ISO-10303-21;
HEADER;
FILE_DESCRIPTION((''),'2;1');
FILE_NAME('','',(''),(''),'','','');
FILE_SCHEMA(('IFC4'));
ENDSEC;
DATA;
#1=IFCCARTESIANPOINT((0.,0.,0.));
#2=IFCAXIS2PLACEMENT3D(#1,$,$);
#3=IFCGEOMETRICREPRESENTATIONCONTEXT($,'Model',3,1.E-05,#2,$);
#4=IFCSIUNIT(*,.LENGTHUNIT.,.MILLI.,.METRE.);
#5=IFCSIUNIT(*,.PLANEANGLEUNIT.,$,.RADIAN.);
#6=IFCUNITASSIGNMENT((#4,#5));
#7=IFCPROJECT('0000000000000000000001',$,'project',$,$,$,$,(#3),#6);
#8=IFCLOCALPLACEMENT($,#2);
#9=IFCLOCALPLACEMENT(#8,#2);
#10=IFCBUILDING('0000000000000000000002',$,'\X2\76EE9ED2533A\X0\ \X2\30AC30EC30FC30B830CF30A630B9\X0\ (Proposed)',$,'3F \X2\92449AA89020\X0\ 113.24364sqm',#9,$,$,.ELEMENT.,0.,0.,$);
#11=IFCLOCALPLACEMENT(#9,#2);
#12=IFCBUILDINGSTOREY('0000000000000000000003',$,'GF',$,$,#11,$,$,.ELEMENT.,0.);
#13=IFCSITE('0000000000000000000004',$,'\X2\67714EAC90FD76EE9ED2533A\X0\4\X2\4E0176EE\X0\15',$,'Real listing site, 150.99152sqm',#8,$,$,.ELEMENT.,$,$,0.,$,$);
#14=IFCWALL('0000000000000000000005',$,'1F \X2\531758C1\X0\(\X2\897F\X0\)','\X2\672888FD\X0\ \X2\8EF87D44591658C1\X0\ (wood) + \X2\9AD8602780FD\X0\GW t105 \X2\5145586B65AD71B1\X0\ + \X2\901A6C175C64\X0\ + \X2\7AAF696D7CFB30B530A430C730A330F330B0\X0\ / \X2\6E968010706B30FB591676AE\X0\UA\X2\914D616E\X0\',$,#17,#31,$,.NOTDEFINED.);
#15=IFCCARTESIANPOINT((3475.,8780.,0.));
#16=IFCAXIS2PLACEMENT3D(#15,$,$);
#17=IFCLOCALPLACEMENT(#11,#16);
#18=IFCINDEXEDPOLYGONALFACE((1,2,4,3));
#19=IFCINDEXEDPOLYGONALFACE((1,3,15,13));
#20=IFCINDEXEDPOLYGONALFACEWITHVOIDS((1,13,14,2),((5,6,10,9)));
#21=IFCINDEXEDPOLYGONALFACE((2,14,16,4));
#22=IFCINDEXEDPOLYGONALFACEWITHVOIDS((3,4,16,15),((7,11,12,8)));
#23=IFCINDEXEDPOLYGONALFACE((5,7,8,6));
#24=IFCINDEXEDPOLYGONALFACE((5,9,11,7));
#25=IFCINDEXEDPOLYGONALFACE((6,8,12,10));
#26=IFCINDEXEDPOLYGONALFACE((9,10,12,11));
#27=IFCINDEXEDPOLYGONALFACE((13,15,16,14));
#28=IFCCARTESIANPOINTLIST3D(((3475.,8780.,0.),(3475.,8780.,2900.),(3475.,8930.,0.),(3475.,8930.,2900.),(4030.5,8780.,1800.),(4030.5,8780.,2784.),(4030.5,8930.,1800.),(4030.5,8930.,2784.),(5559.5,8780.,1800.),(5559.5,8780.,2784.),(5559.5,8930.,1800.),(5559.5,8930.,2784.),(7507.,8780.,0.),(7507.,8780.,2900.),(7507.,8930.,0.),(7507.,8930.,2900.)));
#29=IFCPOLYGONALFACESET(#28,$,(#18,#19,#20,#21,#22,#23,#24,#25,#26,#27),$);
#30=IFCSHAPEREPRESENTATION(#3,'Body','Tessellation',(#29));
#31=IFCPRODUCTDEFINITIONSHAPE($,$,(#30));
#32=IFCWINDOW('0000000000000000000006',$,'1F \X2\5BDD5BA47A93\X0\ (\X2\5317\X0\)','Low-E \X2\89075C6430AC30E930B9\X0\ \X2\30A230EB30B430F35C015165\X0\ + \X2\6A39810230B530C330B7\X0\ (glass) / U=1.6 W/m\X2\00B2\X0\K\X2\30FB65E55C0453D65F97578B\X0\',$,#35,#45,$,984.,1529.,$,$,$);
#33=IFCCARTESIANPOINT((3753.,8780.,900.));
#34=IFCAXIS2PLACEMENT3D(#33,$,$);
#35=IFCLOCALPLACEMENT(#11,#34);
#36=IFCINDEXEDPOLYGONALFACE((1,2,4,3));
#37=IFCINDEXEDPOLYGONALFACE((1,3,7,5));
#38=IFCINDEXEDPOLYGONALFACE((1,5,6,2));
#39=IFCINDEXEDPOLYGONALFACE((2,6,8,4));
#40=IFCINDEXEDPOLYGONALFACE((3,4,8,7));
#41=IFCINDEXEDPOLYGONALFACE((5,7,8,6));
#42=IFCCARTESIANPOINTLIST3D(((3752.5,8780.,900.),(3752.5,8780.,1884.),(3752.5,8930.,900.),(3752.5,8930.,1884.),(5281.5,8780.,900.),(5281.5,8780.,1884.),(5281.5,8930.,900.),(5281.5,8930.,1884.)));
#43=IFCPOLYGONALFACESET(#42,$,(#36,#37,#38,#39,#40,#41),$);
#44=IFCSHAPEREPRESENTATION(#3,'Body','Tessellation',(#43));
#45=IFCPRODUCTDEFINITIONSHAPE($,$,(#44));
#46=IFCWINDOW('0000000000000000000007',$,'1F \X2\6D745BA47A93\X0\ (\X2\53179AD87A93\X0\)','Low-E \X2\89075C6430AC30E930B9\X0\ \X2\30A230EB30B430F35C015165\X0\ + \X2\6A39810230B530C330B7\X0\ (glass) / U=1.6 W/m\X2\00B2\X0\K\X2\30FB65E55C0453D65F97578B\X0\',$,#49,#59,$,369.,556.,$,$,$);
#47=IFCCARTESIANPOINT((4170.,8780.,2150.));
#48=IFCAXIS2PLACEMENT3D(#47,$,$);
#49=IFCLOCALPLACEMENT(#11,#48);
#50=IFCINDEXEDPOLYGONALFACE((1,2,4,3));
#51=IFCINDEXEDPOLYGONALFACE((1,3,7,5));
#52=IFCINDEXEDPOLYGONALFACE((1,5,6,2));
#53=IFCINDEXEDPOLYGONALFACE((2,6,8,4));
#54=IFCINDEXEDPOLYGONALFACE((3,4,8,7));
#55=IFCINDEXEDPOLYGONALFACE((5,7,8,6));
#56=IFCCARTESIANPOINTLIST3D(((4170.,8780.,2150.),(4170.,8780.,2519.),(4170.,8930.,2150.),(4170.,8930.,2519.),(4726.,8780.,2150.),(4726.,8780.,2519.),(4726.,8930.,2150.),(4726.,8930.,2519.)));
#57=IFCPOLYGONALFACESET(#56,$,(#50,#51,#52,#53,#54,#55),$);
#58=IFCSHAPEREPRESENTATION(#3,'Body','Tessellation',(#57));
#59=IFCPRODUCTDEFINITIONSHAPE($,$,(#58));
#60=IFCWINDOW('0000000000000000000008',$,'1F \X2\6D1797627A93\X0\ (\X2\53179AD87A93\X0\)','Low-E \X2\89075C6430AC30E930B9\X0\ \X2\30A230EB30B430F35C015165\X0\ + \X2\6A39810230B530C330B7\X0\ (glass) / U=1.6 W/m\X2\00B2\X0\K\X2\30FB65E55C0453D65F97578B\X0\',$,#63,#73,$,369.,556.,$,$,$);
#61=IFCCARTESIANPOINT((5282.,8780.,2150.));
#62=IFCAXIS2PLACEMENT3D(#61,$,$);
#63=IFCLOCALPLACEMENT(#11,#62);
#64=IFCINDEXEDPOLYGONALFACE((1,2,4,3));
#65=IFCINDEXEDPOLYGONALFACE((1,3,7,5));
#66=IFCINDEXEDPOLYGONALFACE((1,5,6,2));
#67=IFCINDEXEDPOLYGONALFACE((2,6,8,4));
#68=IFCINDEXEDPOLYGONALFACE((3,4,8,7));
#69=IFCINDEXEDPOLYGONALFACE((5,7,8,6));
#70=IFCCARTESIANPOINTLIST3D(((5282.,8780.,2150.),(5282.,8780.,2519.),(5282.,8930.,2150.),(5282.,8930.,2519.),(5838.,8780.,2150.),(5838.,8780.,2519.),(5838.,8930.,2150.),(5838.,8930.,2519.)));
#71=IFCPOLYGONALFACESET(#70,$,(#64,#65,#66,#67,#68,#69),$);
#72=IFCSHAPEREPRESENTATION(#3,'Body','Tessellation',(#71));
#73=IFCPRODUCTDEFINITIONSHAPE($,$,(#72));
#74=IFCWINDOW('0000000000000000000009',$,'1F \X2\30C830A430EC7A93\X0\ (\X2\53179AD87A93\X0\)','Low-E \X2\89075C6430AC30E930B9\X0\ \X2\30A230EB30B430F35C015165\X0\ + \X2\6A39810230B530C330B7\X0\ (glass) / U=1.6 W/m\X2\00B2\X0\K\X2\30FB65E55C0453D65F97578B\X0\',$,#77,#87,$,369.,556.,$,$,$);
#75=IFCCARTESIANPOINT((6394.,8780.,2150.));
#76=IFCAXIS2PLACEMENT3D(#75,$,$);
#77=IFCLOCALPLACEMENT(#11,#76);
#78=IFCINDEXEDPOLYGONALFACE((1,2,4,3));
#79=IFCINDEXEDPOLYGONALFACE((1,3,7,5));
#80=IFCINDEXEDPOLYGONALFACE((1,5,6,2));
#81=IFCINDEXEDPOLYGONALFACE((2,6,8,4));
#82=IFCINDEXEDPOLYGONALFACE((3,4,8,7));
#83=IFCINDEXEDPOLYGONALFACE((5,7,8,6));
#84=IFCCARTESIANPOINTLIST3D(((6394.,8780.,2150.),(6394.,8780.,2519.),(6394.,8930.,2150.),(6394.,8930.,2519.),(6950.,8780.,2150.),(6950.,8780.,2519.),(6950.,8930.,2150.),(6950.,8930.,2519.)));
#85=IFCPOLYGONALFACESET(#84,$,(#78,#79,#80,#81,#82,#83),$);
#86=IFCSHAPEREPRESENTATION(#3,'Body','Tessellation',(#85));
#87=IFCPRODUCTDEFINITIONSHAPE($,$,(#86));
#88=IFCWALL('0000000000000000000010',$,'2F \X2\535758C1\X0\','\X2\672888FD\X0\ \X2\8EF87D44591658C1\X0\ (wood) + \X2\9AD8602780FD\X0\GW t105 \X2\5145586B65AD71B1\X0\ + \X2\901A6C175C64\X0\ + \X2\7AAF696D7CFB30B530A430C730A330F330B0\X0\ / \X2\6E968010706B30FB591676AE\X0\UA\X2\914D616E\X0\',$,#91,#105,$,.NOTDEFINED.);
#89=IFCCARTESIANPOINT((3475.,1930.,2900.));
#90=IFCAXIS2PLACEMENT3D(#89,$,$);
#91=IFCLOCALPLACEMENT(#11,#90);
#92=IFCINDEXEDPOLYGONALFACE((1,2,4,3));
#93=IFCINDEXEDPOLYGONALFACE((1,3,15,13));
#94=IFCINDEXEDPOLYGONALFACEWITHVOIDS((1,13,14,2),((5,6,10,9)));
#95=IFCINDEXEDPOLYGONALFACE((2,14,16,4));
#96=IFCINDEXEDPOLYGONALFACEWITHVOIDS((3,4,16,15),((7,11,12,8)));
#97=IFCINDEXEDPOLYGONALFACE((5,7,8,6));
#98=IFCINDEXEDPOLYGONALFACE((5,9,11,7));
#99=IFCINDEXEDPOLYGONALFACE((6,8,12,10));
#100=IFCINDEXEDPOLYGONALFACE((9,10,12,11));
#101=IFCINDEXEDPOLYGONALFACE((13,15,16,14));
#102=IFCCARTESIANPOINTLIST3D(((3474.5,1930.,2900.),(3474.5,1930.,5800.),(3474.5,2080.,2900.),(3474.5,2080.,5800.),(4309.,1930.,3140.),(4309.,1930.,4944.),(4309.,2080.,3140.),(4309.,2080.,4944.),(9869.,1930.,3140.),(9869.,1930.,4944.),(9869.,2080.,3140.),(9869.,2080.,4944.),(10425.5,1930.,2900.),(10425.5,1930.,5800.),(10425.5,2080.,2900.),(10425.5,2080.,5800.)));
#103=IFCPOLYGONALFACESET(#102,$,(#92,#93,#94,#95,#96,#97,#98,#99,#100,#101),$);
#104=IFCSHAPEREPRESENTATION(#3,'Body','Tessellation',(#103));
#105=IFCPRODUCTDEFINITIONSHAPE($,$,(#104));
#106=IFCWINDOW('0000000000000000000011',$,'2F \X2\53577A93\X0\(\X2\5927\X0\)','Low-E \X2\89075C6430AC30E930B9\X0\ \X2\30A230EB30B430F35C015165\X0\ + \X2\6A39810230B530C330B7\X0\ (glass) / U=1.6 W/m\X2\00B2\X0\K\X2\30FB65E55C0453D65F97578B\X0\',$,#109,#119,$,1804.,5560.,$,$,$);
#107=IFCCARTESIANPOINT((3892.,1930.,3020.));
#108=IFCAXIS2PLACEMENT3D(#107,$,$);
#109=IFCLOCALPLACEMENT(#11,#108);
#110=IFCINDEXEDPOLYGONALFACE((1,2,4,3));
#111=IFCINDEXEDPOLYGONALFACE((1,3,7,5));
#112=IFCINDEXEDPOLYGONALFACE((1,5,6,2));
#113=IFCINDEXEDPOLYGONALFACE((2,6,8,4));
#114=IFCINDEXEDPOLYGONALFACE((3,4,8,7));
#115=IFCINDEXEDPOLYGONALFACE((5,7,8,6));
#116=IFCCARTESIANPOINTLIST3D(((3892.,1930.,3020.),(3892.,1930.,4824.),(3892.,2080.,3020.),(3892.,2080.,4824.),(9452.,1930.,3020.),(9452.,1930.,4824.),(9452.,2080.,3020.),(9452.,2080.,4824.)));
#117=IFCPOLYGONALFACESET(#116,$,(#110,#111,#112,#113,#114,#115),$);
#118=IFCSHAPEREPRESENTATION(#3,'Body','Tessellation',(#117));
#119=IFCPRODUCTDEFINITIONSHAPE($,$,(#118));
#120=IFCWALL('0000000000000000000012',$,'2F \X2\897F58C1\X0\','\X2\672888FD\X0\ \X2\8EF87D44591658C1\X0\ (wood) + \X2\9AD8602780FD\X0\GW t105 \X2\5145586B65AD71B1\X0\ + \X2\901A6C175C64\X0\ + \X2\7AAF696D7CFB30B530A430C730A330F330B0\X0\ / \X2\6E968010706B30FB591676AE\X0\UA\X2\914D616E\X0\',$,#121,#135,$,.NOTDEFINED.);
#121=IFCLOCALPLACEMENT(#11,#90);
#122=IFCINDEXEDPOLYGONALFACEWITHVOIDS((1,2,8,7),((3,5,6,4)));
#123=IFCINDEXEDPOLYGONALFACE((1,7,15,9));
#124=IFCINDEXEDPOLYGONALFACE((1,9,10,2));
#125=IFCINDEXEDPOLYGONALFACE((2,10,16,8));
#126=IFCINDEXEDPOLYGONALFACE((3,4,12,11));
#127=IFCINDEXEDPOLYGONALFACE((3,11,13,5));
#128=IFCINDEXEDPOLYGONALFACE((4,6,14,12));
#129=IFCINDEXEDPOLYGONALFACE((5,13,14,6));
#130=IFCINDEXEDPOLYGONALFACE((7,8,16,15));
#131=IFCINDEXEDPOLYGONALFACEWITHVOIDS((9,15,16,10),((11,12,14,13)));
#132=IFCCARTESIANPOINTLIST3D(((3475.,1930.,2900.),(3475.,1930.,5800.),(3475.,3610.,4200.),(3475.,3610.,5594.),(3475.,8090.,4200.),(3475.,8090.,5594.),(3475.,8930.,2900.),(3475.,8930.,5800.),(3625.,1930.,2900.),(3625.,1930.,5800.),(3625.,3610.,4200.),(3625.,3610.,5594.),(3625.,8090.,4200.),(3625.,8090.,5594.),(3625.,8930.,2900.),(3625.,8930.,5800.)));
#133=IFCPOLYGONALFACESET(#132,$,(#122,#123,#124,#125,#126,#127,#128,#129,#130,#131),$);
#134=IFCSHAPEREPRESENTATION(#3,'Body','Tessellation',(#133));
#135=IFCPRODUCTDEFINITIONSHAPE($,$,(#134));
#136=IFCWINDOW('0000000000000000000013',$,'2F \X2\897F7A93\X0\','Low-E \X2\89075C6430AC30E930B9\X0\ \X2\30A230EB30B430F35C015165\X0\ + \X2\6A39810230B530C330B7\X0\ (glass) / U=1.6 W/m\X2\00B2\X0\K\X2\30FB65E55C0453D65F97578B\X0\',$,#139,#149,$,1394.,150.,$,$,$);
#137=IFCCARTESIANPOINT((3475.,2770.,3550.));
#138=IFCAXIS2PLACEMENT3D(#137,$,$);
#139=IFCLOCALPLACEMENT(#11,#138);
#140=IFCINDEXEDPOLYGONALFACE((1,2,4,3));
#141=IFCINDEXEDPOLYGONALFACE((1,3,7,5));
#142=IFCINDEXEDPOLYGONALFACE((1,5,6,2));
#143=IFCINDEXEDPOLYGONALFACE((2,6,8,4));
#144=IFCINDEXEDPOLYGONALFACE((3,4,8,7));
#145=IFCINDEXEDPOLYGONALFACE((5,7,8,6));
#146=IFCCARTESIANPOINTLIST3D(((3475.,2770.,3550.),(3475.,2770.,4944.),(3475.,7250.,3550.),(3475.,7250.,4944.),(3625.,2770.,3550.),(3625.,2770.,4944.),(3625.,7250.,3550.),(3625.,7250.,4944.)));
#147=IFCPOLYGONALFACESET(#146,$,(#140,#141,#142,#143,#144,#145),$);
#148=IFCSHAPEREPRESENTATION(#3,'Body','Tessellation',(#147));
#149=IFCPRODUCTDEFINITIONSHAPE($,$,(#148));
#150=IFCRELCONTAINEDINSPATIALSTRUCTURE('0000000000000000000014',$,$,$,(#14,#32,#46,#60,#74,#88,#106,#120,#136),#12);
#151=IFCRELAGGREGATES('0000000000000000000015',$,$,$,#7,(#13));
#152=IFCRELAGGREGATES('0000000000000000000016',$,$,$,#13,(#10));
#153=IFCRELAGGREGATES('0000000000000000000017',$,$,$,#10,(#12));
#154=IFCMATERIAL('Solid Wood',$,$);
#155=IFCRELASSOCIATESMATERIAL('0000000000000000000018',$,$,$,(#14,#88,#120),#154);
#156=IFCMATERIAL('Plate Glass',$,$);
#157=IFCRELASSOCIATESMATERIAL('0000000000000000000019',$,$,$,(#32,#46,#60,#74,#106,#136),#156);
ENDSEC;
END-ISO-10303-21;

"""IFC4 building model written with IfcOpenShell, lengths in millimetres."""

from ifc_helpers import new_model, si_unit, frame, frame_2d, origin, place, context, project, spatial, rectangle, extrude, material, element, fill, save


model = new_model("IFC4")

# Units and contexts
model_context = context("Model", 3, precision=1e-05, world=origin())
ifc_project = project(units=[si_unit("LENGTHUNIT", "METRE", prefix="MILLI"), si_unit("PLANEANGLEUNIT", "RADIAN")], contexts=[model_context])

# Site, building, storey
site_placement = place(None, origin())
site = spatial("IfcSite", under=ifc_project, at=site_placement, Name="東京都目黒区4丁目15", ObjectType="Real listing site, 150.99152sqm", CompositionType="ELEMENT", RefElevation=0.0)
building_placement = place(site_placement, origin())
building = spatial("IfcBuilding", under=site, at=building_placement, Name="目黒区 ガレージハウス (Proposed)", ObjectType="3F 鉄骨造 113.24364sqm", CompositionType="ELEMENT", ElevationOfRefHeight=0.0, ElevationOfTerrain=0.0)
storey_placement = place(building_placement, origin())
storey = spatial("IfcBuildingStorey", under=building, at=storey_placement, Name="GF", CompositionType="ELEMENT", Elevation=0.0)

# Shared definitions
ifc_material_1 = material(Name="Solid Wood")

# Shared definitions
ifc_material_2 = material(Name="Plate Glass")

# Wall, openings, windows
wall_1_placement = place(storey_placement, frame((3475.0, 8780.0, 0.0)))
wall_1 = element("IfcWall", 1, at=wall_1_placement, inside=storey, material=ifc_material_1, Name="1F 北壁(西)", Description="木製 軸組外壁 (wood) + 高性能GW t105 充填断熱 + 通気層 + 窯業系サイディング / 準耐火・外皮UA配慮", PredefinedType="NOTDEFINED", context=model_context, shape_type="SweptSolid", body=[
    extrude(rectangle(XDim=4032.0, YDim=150.0, at=frame_2d((2016.0, 75.0))), frame((3475.0, 8780.0, 0.0)), (0.0, 0.0, 1.0), 2900.0),
])
opening_1_placement = place(storey_placement, frame((3753.0, 8780.0, 900.0)))
opening_1 = element("IfcOpeningElement", 2, at=opening_1_placement, cuts=wall_1, PredefinedType="NOTDEFINED", context=model_context, shape_type="SweptSolid", body=[
    extrude(rectangle(XDim=1529.0, YDim=150.0, at=frame_2d((764.0, 75.0))), frame((3753.0, 8780.0, 900.0)), (0.0, 0.0, 1.0), 984.0),
])
opening_2_placement = place(storey_placement, frame((4170.0, 8780.0, 2150.0)))
opening_2 = element("IfcOpeningElement", 3, at=opening_2_placement, cuts=wall_1, PredefinedType="NOTDEFINED", context=model_context, shape_type="SweptSolid", body=[
    extrude(rectangle(XDim=556.0, YDim=150.0, at=frame_2d((278.0, 75.0))), frame((4170.0, 8780.0, 2150.0)), (0.0, 0.0, 1.0), 369.0),
])
opening_3_placement = place(storey_placement, frame((5282.0, 8780.0, 2150.0)))
opening_3 = element("IfcOpeningElement", 4, at=opening_3_placement, cuts=wall_1, PredefinedType="NOTDEFINED", context=model_context, shape_type="SweptSolid", body=[
    extrude(rectangle(XDim=556.0, YDim=150.0, at=frame_2d((278.0, 75.0))), frame((5282.0, 8780.0, 2150.0)), (0.0, 0.0, 1.0), 369.0),
])
opening_4_placement = place(storey_placement, frame((6394.0, 8780.0, 2150.0)))
opening_4 = element("IfcOpeningElement", 5, at=opening_4_placement, cuts=wall_1, PredefinedType="NOTDEFINED", context=model_context, shape_type="SweptSolid", body=[
    extrude(rectangle(XDim=556.0, YDim=150.0, at=frame_2d((278.0, 75.0))), frame((6394.0, 8780.0, 2150.0)), (0.0, 0.0, 1.0), 369.0),
])
window_1_placement = place(storey_placement, frame((3753.0, 8780.0, 900.0)))
window_1 = element("IfcWindow", 6, at=window_1_placement, inside=storey, material=ifc_material_2, Name="1F 寝室窓 (北)", Description="Low-E 複層ガラス アルゴン封入 + 樹脂サッシ (glass) / U=1.6 W/m²K・日射取得型", OverallHeight=984.0, OverallWidth=1529.0, context=model_context, shape_type="SweptSolid", body=[
    extrude(rectangle(XDim=1529.0, YDim=150.0, at=frame_2d((764.0, 75.0))), frame((3753.0, 8780.0, 900.0)), (0.0, 0.0, 1.0), 984.0),
])
fill(opening_1, window_1)
window_2_placement = place(storey_placement, frame((4170.0, 8780.0, 2150.0)))
window_2 = element("IfcWindow", 7, at=window_2_placement, inside=storey, material=ifc_material_2, Name="1F 浴室窓 (北高窓)", Description="Low-E 複層ガラス アルゴン封入 + 樹脂サッシ (glass) / U=1.6 W/m²K・日射取得型", OverallHeight=369.0, OverallWidth=556.0, context=model_context, shape_type="SweptSolid", body=[
    extrude(rectangle(XDim=556.0, YDim=150.0, at=frame_2d((278.0, 75.0))), frame((4170.0, 8780.0, 2150.0)), (0.0, 0.0, 1.0), 369.0),
])
fill(opening_2, window_2)
window_3_placement = place(storey_placement, frame((5282.0, 8780.0, 2150.0)))
window_3 = element("IfcWindow", 8, at=window_3_placement, inside=storey, material=ifc_material_2, Name="1F 洗面窓 (北高窓)", Description="Low-E 複層ガラス アルゴン封入 + 樹脂サッシ (glass) / U=1.6 W/m²K・日射取得型", OverallHeight=369.0, OverallWidth=556.0, context=model_context, shape_type="SweptSolid", body=[
    extrude(rectangle(XDim=556.0, YDim=150.0, at=frame_2d((278.0, 75.0))), frame((5282.0, 8780.0, 2150.0)), (0.0, 0.0, 1.0), 369.0),
])
fill(opening_3, window_3)
window_4_placement = place(storey_placement, frame((6394.0, 8780.0, 2150.0)))
window_4 = element("IfcWindow", 9, at=window_4_placement, inside=storey, material=ifc_material_2, Name="1F トイレ窓 (北高窓)", Description="Low-E 複層ガラス アルゴン封入 + 樹脂サッシ (glass) / U=1.6 W/m²K・日射取得型", OverallHeight=369.0, OverallWidth=556.0, context=model_context, shape_type="SweptSolid", body=[
    extrude(rectangle(XDim=556.0, YDim=150.0, at=frame_2d((278.0, 75.0))), frame((6394.0, 8780.0, 2150.0)), (0.0, 0.0, 1.0), 369.0),
])
fill(opening_4, window_4)

# Walls, openings, windows
wall_2_placement = place(storey_placement, frame((3475.0, 1930.0, 2900.0)))
wall_2 = element("IfcWall", 10, at=wall_2_placement, inside=storey, material=ifc_material_1, Name="2F 南壁", Description="木製 軸組外壁 (wood) + 高性能GW t105 充填断熱 + 通気層 + 窯業系サイディング / 準耐火・外皮UA配慮", PredefinedType="NOTDEFINED", context=model_context, shape_type="SweptSolid", body=[
    extrude(rectangle(XDim=6951.0, YDim=150.0, at=frame_2d((3475.0, 75.0))), frame((3475.0, 1930.0, 2900.0)), (0.0, 0.0, 1.0), 2900.0),
])
opening_5_placement = place(storey_placement, frame((3892.0, 1930.0, 3020.0)))
opening_5 = element("IfcOpeningElement", 11, at=opening_5_placement, cuts=wall_2, PredefinedType="NOTDEFINED", context=model_context, shape_type="SweptSolid", body=[
    extrude(rectangle(XDim=5560.0, YDim=150.0, at=frame_2d((2780.0, 75.0))), frame((3892.0, 1930.0, 3020.0)), (0.0, 0.0, 1.0), 1804.0),
])
window_5_placement = place(storey_placement, frame((3892.0, 1930.0, 3020.0)))
window_5 = element("IfcWindow", 12, at=window_5_placement, inside=storey, material=ifc_material_2, Name="2F 南窓(大)", Description="Low-E 複層ガラス アルゴン封入 + 樹脂サッシ (glass) / U=1.6 W/m²K・日射取得型", OverallHeight=1804.0, OverallWidth=5560.0, context=model_context, shape_type="SweptSolid", body=[
    extrude(rectangle(XDim=5560.0, YDim=150.0, at=frame_2d((2780.0, 75.0))), frame((3892.0, 1930.0, 3020.0)), (0.0, 0.0, 1.0), 1804.0),
])
fill(opening_5, window_5)
wall_3_placement = place(storey_placement, frame((3475.0, 1930.0, 2900.0)))
wall_3 = element("IfcWall", 13, at=wall_3_placement, inside=storey, material=ifc_material_1, Name="2F 西壁", Description="木製 軸組外壁 (wood) + 高性能GW t105 充填断熱 + 通気層 + 窯業系サイディング / 準耐火・外皮UA配慮", PredefinedType="NOTDEFINED", context=model_context, shape_type="SweptSolid", body=[
    extrude(rectangle(XDim=150.0, YDim=7000.0, at=frame_2d((75.0, 3500.0))), frame((3475.0, 1930.0, 2900.0)), (0.0, 0.0, 1.0), 2900.0),
])
opening_6_placement = place(storey_placement, frame((3475.0, 2770.0, 3550.0)))
opening_6 = element("IfcOpeningElement", 14, at=opening_6_placement, cuts=wall_3, PredefinedType="NOTDEFINED", context=model_context, shape_type="SweptSolid", body=[
    extrude(rectangle(XDim=150.0, YDim=4480.0, at=frame_2d((75.0, 2240.0))), frame((3475.0, 2770.0, 3550.0)), (0.0, 0.0, 1.0), 1394.0),
])
window_6_placement = place(storey_placement, frame((3475.0, 2770.0, 3550.0)))
window_6 = element("IfcWindow", 15, at=window_6_placement, inside=storey, material=ifc_material_2, Name="2F 西窓", Description="Low-E 複層ガラス アルゴン封入 + 樹脂サッシ (glass) / U=1.6 W/m²K・日射取得型", OverallHeight=1394.0, OverallWidth=150.0, context=model_context, shape_type="SweptSolid", body=[
    extrude(rectangle(XDim=150.0, YDim=4480.0, at=frame_2d((75.0, 2240.0))), frame((3475.0, 2770.0, 3550.0)), (0.0, 0.0, 1.0), 1394.0),
])
fill(opening_6, window_6)

save(model, "model.ifc")
